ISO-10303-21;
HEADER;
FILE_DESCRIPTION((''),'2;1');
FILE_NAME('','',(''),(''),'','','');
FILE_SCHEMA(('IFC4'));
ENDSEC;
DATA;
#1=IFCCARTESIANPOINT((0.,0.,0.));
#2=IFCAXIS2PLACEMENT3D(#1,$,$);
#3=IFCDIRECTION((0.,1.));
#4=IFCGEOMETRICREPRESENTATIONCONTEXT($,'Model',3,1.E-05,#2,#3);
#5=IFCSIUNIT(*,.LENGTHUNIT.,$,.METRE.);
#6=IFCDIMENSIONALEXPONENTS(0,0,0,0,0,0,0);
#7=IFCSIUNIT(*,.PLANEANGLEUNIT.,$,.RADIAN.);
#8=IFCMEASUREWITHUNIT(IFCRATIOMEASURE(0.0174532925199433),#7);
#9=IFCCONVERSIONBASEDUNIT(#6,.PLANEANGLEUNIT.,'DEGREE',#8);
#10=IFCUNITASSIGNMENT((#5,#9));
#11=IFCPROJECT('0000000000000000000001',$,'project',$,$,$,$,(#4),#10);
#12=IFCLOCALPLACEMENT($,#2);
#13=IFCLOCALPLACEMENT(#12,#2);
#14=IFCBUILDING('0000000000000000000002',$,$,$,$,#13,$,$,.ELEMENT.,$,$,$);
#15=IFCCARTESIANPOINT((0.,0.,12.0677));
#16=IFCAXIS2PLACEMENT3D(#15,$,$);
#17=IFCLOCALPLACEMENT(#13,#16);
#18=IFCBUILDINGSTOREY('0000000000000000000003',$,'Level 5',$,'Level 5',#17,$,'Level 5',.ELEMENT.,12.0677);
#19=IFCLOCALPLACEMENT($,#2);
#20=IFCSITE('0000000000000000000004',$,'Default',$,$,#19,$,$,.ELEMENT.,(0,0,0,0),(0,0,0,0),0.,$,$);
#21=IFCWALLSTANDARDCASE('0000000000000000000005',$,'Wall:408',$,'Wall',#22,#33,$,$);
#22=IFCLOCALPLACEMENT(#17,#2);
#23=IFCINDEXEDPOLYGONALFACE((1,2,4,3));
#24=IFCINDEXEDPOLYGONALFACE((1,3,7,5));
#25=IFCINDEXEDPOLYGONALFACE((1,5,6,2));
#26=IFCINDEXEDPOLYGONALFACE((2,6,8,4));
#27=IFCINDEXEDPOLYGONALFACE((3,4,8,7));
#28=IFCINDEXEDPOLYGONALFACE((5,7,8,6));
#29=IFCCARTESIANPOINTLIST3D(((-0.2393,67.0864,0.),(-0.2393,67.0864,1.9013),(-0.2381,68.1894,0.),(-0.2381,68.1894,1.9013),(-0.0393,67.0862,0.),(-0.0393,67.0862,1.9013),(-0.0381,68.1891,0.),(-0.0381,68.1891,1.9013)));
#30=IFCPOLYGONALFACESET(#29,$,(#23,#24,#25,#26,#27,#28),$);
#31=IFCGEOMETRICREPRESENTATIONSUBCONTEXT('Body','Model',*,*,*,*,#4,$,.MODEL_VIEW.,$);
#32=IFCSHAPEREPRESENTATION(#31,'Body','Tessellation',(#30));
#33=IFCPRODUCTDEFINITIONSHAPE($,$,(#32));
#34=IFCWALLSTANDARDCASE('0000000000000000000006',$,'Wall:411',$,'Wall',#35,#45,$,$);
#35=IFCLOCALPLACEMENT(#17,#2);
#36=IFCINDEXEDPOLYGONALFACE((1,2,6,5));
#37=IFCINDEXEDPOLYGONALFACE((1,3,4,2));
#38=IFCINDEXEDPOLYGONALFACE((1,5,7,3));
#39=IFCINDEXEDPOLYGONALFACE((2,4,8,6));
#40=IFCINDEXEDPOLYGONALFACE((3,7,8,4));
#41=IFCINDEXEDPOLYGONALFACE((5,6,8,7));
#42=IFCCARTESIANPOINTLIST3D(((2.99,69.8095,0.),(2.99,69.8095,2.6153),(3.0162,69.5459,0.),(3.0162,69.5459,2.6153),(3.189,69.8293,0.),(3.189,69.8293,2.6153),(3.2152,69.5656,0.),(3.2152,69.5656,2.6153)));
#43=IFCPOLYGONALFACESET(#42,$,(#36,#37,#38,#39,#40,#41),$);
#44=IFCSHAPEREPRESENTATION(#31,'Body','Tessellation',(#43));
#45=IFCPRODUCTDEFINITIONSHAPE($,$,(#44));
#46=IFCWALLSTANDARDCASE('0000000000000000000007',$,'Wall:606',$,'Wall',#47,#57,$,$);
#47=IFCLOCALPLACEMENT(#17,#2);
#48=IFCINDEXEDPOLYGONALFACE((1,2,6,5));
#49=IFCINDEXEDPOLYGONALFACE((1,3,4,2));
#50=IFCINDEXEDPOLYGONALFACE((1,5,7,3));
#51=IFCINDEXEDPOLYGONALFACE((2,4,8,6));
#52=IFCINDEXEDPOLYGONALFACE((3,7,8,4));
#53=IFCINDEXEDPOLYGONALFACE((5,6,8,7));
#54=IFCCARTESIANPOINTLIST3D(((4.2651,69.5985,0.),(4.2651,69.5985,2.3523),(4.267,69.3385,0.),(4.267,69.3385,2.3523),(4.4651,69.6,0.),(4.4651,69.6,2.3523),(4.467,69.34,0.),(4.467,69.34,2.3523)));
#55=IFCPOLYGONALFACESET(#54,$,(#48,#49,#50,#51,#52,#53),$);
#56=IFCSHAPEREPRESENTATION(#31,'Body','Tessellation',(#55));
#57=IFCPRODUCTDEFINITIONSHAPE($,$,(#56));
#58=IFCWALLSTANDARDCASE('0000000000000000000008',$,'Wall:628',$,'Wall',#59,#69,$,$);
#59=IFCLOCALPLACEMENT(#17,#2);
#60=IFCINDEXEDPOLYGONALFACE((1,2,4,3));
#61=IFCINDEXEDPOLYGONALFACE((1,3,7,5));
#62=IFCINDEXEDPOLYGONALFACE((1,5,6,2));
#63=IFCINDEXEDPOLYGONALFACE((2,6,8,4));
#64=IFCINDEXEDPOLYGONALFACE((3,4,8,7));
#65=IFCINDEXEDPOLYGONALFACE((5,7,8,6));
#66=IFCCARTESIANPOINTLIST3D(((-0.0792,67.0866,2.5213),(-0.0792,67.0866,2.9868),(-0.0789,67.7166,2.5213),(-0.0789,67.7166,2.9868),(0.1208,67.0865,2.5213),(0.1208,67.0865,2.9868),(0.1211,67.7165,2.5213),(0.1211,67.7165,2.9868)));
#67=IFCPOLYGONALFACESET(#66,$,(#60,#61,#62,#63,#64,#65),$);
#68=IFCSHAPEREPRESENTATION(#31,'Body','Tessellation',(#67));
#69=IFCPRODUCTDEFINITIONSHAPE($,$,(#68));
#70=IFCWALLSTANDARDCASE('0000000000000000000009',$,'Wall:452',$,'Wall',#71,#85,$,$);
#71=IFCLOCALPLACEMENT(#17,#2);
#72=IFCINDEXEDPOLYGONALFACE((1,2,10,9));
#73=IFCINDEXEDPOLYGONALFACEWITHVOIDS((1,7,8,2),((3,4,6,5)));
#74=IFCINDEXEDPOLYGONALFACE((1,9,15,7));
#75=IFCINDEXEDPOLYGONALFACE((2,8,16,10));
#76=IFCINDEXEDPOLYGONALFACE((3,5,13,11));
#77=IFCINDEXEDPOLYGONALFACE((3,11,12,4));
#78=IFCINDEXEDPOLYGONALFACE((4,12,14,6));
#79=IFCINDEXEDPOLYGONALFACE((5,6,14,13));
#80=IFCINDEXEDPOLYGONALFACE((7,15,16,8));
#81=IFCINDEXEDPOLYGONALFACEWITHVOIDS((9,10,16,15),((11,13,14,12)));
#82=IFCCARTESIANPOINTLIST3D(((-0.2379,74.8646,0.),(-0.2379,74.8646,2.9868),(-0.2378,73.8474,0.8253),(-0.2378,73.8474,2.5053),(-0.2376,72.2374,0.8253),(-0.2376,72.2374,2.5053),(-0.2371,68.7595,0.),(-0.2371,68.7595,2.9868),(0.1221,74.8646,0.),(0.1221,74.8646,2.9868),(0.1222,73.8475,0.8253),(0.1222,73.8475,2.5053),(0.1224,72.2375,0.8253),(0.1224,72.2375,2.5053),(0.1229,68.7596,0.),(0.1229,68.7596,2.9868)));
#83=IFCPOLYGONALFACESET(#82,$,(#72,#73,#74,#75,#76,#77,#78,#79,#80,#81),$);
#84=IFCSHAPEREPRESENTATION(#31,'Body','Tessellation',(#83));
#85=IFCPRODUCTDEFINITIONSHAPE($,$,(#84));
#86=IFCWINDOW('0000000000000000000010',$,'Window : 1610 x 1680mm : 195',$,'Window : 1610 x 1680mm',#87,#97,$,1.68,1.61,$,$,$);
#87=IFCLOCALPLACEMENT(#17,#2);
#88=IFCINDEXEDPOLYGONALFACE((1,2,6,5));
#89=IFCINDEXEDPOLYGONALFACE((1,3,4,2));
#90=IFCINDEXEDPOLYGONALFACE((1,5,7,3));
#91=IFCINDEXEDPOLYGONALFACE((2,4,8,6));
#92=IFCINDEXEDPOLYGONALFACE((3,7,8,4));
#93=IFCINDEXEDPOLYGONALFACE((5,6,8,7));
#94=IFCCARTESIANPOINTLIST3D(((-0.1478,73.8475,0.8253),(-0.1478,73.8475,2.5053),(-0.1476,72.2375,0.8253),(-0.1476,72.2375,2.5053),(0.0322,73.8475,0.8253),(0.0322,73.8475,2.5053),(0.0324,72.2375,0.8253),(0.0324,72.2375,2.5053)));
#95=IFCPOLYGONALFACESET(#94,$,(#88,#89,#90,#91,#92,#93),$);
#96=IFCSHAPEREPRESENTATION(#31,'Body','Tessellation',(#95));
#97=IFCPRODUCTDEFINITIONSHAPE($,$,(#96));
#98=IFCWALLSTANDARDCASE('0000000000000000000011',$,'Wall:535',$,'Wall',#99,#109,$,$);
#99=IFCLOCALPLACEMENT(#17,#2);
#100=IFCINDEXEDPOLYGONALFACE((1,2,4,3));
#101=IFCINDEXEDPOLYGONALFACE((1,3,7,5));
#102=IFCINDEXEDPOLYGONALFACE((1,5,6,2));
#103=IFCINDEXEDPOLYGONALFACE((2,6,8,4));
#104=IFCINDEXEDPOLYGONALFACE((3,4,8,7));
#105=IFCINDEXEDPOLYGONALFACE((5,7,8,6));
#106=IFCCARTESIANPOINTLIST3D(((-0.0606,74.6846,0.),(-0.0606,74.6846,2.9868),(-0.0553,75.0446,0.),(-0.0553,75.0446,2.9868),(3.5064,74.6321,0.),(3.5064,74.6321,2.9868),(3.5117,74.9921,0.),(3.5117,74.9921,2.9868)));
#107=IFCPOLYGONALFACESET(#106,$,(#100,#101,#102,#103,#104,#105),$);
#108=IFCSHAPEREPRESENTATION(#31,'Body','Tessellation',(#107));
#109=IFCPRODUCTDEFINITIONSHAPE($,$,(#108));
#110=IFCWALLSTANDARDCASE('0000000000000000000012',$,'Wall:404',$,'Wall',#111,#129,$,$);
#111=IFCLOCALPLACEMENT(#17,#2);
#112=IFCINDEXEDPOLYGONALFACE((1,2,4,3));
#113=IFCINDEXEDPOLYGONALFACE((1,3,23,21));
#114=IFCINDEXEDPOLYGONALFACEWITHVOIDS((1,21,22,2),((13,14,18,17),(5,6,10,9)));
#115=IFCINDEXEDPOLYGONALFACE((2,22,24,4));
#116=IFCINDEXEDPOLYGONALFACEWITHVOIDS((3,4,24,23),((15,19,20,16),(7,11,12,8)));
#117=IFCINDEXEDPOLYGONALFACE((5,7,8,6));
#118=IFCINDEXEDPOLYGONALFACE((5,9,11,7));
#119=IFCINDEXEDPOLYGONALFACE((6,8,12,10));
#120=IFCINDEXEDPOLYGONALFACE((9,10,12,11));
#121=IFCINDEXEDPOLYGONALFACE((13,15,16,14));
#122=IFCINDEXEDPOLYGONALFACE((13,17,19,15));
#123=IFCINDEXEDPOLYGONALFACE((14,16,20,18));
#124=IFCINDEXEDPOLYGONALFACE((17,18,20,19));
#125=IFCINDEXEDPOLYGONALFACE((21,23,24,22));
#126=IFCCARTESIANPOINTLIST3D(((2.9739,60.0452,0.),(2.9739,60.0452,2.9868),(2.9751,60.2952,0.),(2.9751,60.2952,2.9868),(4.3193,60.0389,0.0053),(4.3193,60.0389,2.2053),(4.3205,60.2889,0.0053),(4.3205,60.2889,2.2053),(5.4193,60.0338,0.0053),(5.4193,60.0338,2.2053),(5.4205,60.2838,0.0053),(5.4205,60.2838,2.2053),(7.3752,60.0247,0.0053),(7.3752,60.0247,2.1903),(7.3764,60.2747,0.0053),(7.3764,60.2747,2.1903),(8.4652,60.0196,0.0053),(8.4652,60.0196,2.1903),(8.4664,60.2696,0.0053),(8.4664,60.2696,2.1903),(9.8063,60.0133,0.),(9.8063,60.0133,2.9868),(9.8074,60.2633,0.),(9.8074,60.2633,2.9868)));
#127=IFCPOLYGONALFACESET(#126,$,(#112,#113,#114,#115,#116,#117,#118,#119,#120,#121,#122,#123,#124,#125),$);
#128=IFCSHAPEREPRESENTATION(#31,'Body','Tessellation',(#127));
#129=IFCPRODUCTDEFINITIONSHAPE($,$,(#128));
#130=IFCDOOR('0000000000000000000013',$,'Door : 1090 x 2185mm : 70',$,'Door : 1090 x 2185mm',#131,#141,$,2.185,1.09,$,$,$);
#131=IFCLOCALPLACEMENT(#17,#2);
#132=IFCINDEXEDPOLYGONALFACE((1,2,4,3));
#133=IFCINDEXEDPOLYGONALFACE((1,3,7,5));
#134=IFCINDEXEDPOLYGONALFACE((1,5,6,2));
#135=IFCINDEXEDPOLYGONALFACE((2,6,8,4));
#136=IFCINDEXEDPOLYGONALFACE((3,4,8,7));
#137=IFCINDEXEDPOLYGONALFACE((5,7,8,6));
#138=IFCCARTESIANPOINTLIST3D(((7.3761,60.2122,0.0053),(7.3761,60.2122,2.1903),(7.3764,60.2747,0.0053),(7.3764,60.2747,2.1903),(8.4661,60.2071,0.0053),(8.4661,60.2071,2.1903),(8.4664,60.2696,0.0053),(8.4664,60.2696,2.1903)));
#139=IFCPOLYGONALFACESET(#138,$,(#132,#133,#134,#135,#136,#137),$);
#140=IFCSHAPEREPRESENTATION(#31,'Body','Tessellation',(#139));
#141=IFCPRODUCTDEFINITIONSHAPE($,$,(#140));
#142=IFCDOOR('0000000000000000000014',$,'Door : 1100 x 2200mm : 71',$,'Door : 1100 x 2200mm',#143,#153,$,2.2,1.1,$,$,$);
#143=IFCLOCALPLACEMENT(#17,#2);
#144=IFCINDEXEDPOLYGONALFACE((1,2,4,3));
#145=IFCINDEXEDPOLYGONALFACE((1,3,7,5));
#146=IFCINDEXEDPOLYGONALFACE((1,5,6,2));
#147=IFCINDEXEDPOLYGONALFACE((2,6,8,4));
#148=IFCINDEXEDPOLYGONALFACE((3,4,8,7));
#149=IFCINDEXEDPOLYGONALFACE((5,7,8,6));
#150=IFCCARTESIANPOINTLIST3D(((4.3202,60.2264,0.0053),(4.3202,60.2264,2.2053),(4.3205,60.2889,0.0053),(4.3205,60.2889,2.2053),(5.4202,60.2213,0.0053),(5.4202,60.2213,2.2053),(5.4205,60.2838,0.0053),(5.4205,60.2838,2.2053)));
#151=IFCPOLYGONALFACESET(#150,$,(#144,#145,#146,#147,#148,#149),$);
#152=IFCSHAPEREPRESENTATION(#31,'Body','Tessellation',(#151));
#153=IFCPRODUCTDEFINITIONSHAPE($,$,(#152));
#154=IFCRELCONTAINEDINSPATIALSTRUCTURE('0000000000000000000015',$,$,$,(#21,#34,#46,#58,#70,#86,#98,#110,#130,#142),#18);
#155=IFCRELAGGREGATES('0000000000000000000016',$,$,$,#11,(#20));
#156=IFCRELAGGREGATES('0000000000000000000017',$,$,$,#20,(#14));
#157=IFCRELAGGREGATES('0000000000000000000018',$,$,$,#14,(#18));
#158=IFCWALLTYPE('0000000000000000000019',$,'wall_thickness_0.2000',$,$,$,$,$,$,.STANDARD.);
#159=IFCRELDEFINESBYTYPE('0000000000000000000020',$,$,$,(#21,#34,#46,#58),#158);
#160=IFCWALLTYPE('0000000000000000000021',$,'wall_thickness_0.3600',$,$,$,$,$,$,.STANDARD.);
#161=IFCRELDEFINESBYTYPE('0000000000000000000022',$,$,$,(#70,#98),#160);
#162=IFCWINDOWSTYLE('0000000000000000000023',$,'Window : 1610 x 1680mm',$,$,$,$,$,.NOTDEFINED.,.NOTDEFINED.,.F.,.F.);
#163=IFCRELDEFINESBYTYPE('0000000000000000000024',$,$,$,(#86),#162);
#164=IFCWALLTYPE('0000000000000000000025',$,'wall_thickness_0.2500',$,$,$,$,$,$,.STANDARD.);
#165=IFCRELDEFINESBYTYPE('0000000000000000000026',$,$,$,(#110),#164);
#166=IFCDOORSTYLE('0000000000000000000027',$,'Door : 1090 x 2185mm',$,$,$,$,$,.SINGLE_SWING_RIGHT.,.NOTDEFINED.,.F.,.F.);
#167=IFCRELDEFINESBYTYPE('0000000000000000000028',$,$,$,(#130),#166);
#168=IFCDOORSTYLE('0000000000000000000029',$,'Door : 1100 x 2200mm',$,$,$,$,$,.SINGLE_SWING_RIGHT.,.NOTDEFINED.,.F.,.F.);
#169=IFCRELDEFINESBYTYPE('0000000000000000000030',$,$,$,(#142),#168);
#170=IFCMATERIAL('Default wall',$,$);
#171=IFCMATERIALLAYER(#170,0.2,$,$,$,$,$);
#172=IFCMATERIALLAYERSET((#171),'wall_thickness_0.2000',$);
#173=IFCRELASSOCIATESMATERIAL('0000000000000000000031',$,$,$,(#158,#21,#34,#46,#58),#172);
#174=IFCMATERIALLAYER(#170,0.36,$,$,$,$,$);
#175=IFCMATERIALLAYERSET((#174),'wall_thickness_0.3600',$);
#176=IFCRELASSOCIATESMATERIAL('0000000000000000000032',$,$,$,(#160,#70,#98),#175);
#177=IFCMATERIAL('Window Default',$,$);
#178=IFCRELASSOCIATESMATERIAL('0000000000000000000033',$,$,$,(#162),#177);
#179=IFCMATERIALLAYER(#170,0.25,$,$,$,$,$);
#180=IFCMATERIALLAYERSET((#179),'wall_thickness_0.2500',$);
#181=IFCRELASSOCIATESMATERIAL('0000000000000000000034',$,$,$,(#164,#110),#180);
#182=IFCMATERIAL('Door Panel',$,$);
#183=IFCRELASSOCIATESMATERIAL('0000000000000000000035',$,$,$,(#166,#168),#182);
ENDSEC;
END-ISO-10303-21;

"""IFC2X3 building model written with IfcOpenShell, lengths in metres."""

from ifc_helpers import new_model, entity, si_unit, converted_unit, direction, frame, frame_2d, origin, origin_2d_with_axis, place, context, subcontext, project, spatial, polyline, rectangle, outline, extrude, source, transform, mapped, material, layer, layer_set, layer_usage, type_object, type_shapes, element, fill, save


model = new_model("IFC2X3")

# Units and contexts
model_context = context("Model", 3, precision=1e-05, world=origin(), true_north=direction((0.0, 1.0)))
body_context = subcontext(model_context, "Body", "Model", "MODEL_VIEW")
ifc_project = project(units=[si_unit("LENGTHUNIT", "METRE"), converted_unit("PLANEANGLEUNIT", "DEGREE", entity("IfcRatioMeasure", 0.0174532925199433), si_unit("PLANEANGLEUNIT", "RADIAN"), dimensions=[0, 0, 0, 0, 0, 0, 0])], contexts=[model_context])

# Site, building, storey
site_placement = place(None, origin())
site = spatial("IfcSite", under=ifc_project, at=site_placement, Name="Default", CompositionType="ELEMENT", RefLatitude=(0, 0, 0, 0), RefLongitude=(0, 0, 0, 0), RefElevation=0.0)
placement_1 = place(None, origin())
building_placement = place(placement_1, origin())
building = spatial("IfcBuilding", under=site, at=building_placement, CompositionType="ELEMENT")
storey_placement = place(building_placement, frame((0.0, 0.0, 12.0677)))
storey = spatial("IfcBuildingStorey", under=building, at=storey_placement, Name="Level 5", ObjectType="Level 5", LongName="Level 5", CompositionType="ELEMENT", Elevation=12.0677)

# Walls
ifc_material_1 = material(Name="Default wall")
ifc_layer_1 = layer(ifc_material_1, 0.2)
ifc_layer_set_1 = layer_set([ifc_layer_1], Name="wall_thickness_0.2000")
ifc_layer_usage_1 = layer_usage(ifc_layer_set_1, "AXIS2", "POSITIVE", -0.1)
wall_type_1 = type_object("IfcWallType", Name="wall_thickness_0.2000", PredefinedType="STANDARD", material=ifc_layer_set_1)
wall_1_placement = place(storey_placement, frame((-0.1381, 68.1893, 0.0), z_axis=(0.0, 0.0, 1.0), x_axis=(-0.001112, -0.999999, 0.0)))
element("IfcWallStandardCase", 1, at=wall_1_placement, inside=storey, type_object=wall_type_1, material=ifc_layer_usage_1, Name="Wall:408", ObjectType="Wall", context=body_context, shape_type="SweptSolid", body=[
    extrude(outline(polyline([(1.1029, -0.1), (1.1029, 0.1), (0.0, 0.1), (0.0, -0.1), (1.1029, -0.1)])), origin(), (0.0, 0.0, 1.0), 1.9013),
])
wall_2_placement = place(storey_placement, frame((3.0895, 69.8194, 0.0), z_axis=(0.0, 0.0, 1.0), x_axis=(0.098941, -0.995093, 0.0)))
element("IfcWallStandardCase", 2, at=wall_2_placement, inside=storey, type_object=wall_type_1, material=ifc_layer_usage_1, Name="Wall:411", ObjectType="Wall", context=body_context, shape_type="SweptSolid", body=[
    extrude(outline(polyline([(0.265, -0.1), (0.265, 0.1), (0.0, 0.1), (0.0, -0.1), (0.265, -0.1)])), origin(), (0.0, 0.0, 1.0), 2.6153),
])
wall_3_placement = place(storey_placement, frame((4.367, 69.3392, 0.0), z_axis=(0.0, 0.0, 1.0), x_axis=(-0.007472, 0.999972, 0.0)))
element("IfcWallStandardCase", 3, at=wall_3_placement, inside=storey, type_object=wall_type_1, material=ifc_layer_usage_1, Name="Wall:606", ObjectType="Wall", context=body_context, shape_type="SweptSolid", body=[
    extrude(outline(polyline([(0.26, -0.1), (0.26, 0.1), (0.0, 0.1), (0.0, -0.1), (0.26, -0.1)])), origin(), (0.0, 0.0, 1.0), 2.3523),
])
placement_2 = place(building_placement, frame((0.0, 0.0, 14.589)))
wall_4_placement = place(placement_2, frame((0.0211, 67.7165, 0.0), z_axis=(0.0, 0.0, 1.0), x_axis=(-0.000477, -1.0, 0.0)))
element("IfcWallStandardCase", 4, at=wall_4_placement, inside=storey, type_object=wall_type_1, material=ifc_layer_usage_1, Name="Wall:628", ObjectType="Wall", context=body_context, shape_type="SweptSolid", body=[
    extrude(outline(polyline([(0.63, -0.1), (0.63, 0.1), (0.0, 0.1), (0.0, -0.1), (0.63, -0.1)])), origin(), (0.0, 0.0, 1.0), 0.4655),
])

# Wall, opening, window
ifc_layer_2 = layer(ifc_material_1, 0.36)
ifc_layer_set_2 = layer_set([ifc_layer_2], Name="wall_thickness_0.3600")
ifc_layer_usage_2 = layer_usage(ifc_layer_set_2, "AXIS2", "POSITIVE", -0.18)
wall_type_2 = type_object("IfcWallType", Name="wall_thickness_0.3600", PredefinedType="STANDARD", material=ifc_layer_set_2)
wall_5_placement = place(storey_placement, frame((-0.0579, 74.8646, 0.0), z_axis=(0.0, 0.0, 1.0), x_axis=(0.000137, -1.0, 0.0)))
wall_5 = element("IfcWallStandardCase", 5, at=wall_5_placement, inside=storey, type_object=wall_type_2, material=ifc_layer_usage_2, Name="Wall:452", ObjectType="Wall", context=body_context, shape_type="SweptSolid", body=[
    extrude(outline(polyline([(6.1051, -0.18), (6.1051, 0.18), (0.0, 0.18), (0.0, -0.18), (6.1051, -0.18)])), origin(), (0.0, 0.0, 1.0), 2.9868),
])
opening_1_placement = place(wall_5_placement, frame((1.0171, -0.18, 0.8253)))
opening_1 = element("IfcOpeningElement", 6, at=opening_1_placement, cuts=wall_5, ObjectType="Opening", context=body_context, shape_type="SweptSolid", body=[
    extrude(rectangle(XDim=1.61, YDim=1.68, at=frame_2d((0.84, 0.805), x_axis=(0.0, 1.0))), frame((0.0, 0.0, 0.0), z_axis=(0.0, 1.0, 0.0), x_axis=(0.0, 0.0, 1.0)), (0.0, 0.0, 1.0), 0.36),
])
ifc_material_2 = material(Name="Window Default")
window_style_1 = type_object("IfcWindowStyle", Name="Window : 1610 x 1680mm", ConstructionType="NOTDEFINED", OperationType="NOTDEFINED", ParameterTakesPrecedence=False, Sizeable=False, material=ifc_material_2)
shared_shape_1 = source(origin(), body_context, "Body", "SweptSolid", [
    extrude(rectangle(XDim=0.18, YDim=1.61, at=origin_2d_with_axis()), frame((0.805, 0.18, 0.0), z_axis=(0.0, 0.0, 1.0), x_axis=(0.0, 1.0, 0.0)), (0.0, 0.0, 1.0), 1.68),
])
type_shapes(window_style_1, [shared_shape_1])
window_1_placement = place(opening_1_placement, origin())
window_1 = element("IfcWindow", 7, at=window_1_placement, inside=storey, type_object=window_style_1, Name="Window : 1610 x 1680mm : 195", ObjectType="Window : 1610 x 1680mm", OverallHeight=1.68, OverallWidth=1.61, context=body_context, shape_type="MappedRepresentation", body=[
    mapped(shared_shape_1, transform((0.0, 0.0, 0.0), scale=1.0)),
])
fill(opening_1, window_1)

# Wall
wall_6_placement = place(storey_placement, frame((-0.0579, 74.8646, 0.0), z_axis=(0.0, 0.0, 1.0), x_axis=(0.999892, -0.014708, 0.0)))
element("IfcWallStandardCase", 8, at=wall_6_placement, inside=storey, type_object=wall_type_2, material=ifc_layer_usage_2, Name="Wall:535", ObjectType="Wall", context=body_context, shape_type="SweptSolid", body=[
    extrude(outline(polyline([(3.5674, -0.18), (3.5674, 0.18), (0.0, 0.18), (0.0, -0.18), (3.5674, -0.18)])), origin(), (0.0, 0.0, 1.0), 2.9868),
])

# Wall, openings, doors
ifc_layer_3 = layer(ifc_material_1, 0.25)
ifc_layer_set_3 = layer_set([ifc_layer_3], Name="wall_thickness_0.2500")
ifc_layer_usage_3 = layer_usage(ifc_layer_set_3, "AXIS2", "POSITIVE", -0.125)
wall_type_3 = type_object("IfcWallType", Name="wall_thickness_0.2500", PredefinedType="STANDARD", material=ifc_layer_set_3)
wall_7_placement = place(storey_placement, frame((2.9745, 60.1702, 0.0), z_axis=(0.0, 0.0, 1.0), x_axis=(0.999989, -0.004658, 0.0)))
wall_7 = element("IfcWallStandardCase", 9, at=wall_7_placement, inside=storey, type_object=wall_type_3, material=ifc_layer_usage_3, Name="Wall:404", ObjectType="Wall", context=body_context, shape_type="SweptSolid", body=[
    extrude(outline(polyline([(6.8324, -0.125), (6.8324, 0.125), (0.0, 0.125), (0.0, -0.125), (6.8324, -0.125)])), origin(), (0.0, 0.0, 1.0), 2.9868),
])
opening_2_placement = place(wall_7_placement, frame((4.4013, -0.125, 0.0053)))
opening_2 = element("IfcOpeningElement", 10, at=opening_2_placement, cuts=wall_7, ObjectType="Opening", context=body_context, shape_type="SweptSolid", body=[
    extrude(rectangle(XDim=1.09, YDim=2.185, at=frame_2d((1.0925, 0.545), x_axis=(0.0, 1.0))), frame((0.0, 0.0, 0.0), z_axis=(0.0, 1.0, 0.0), x_axis=(0.0, 0.0, 1.0)), (0.0, 0.0, 1.0), 0.25),
])
opening_3_placement = place(wall_7_placement, frame((1.3454, -0.125, 0.0053)))
opening_3 = element("IfcOpeningElement", 11, at=opening_3_placement, cuts=wall_7, ObjectType="Opening", context=body_context, shape_type="SweptSolid", body=[
    extrude(rectangle(XDim=1.1, YDim=2.2, at=frame_2d((1.1, 0.55), x_axis=(0.0, 1.0))), frame((0.0, 0.0, 0.0), z_axis=(0.0, 1.0, 0.0), x_axis=(0.0, 0.0, 1.0)), (0.0, 0.0, 1.0), 0.25),
])
ifc_material_3 = material(Name="Door Panel")
door_style_1 = type_object("IfcDoorStyle", Name="Door : 1090 x 2185mm", ConstructionType="NOTDEFINED", OperationType="SINGLE_SWING_RIGHT", ParameterTakesPrecedence=False, Sizeable=False, material=ifc_material_3)
shared_shape_2 = source(origin(), body_context, "Body", "SweptSolid", [
    extrude(rectangle(XDim=0.0625, YDim=1.09, at=origin_2d_with_axis()), frame((0.545, 0.2188, 0.0), z_axis=(0.0, 0.0, 1.0), x_axis=(0.0, 1.0, 0.0)), (0.0, 0.0, 1.0), 2.185),
])
type_shapes(door_style_1, [shared_shape_2])
door_1_placement = place(opening_2_placement, origin())
door_1 = element("IfcDoor", 12, at=door_1_placement, inside=storey, type_object=door_style_1, Name="Door : 1090 x 2185mm : 70", ObjectType="Door : 1090 x 2185mm", OverallHeight=2.185, OverallWidth=1.09, context=body_context, shape_type="MappedRepresentation", body=[
    mapped(shared_shape_2, transform((0.0, 0.0, 0.0), scale=1.0)),
])
fill(opening_2, door_1)
door_style_2 = type_object("IfcDoorStyle", Name="Door : 1100 x 2200mm", ConstructionType="NOTDEFINED", OperationType="SINGLE_SWING_RIGHT", ParameterTakesPrecedence=False, Sizeable=False, material=ifc_material_3)
shared_shape_3 = source(origin(), body_context, "Body", "SweptSolid", [
    extrude(rectangle(XDim=0.0625, YDim=1.1, at=origin_2d_with_axis()), frame((0.55, 0.2188, 0.0), z_axis=(0.0, 0.0, 1.0), x_axis=(0.0, 1.0, 0.0)), (0.0, 0.0, 1.0), 2.2),
])
type_shapes(door_style_2, [shared_shape_3])
door_2_placement = place(opening_3_placement, origin())
door_2 = element("IfcDoor", 13, at=door_2_placement, inside=storey, type_object=door_style_2, Name="Door : 1100 x 2200mm : 71", ObjectType="Door : 1100 x 2200mm", OverallHeight=2.2, OverallWidth=1.1, context=body_context, shape_type="MappedRepresentation", body=[
    mapped(shared_shape_3, transform((0.0, 0.0, 0.0), scale=1.0)),
])
fill(opening_3, door_2)

save(model, "model.ifc")
